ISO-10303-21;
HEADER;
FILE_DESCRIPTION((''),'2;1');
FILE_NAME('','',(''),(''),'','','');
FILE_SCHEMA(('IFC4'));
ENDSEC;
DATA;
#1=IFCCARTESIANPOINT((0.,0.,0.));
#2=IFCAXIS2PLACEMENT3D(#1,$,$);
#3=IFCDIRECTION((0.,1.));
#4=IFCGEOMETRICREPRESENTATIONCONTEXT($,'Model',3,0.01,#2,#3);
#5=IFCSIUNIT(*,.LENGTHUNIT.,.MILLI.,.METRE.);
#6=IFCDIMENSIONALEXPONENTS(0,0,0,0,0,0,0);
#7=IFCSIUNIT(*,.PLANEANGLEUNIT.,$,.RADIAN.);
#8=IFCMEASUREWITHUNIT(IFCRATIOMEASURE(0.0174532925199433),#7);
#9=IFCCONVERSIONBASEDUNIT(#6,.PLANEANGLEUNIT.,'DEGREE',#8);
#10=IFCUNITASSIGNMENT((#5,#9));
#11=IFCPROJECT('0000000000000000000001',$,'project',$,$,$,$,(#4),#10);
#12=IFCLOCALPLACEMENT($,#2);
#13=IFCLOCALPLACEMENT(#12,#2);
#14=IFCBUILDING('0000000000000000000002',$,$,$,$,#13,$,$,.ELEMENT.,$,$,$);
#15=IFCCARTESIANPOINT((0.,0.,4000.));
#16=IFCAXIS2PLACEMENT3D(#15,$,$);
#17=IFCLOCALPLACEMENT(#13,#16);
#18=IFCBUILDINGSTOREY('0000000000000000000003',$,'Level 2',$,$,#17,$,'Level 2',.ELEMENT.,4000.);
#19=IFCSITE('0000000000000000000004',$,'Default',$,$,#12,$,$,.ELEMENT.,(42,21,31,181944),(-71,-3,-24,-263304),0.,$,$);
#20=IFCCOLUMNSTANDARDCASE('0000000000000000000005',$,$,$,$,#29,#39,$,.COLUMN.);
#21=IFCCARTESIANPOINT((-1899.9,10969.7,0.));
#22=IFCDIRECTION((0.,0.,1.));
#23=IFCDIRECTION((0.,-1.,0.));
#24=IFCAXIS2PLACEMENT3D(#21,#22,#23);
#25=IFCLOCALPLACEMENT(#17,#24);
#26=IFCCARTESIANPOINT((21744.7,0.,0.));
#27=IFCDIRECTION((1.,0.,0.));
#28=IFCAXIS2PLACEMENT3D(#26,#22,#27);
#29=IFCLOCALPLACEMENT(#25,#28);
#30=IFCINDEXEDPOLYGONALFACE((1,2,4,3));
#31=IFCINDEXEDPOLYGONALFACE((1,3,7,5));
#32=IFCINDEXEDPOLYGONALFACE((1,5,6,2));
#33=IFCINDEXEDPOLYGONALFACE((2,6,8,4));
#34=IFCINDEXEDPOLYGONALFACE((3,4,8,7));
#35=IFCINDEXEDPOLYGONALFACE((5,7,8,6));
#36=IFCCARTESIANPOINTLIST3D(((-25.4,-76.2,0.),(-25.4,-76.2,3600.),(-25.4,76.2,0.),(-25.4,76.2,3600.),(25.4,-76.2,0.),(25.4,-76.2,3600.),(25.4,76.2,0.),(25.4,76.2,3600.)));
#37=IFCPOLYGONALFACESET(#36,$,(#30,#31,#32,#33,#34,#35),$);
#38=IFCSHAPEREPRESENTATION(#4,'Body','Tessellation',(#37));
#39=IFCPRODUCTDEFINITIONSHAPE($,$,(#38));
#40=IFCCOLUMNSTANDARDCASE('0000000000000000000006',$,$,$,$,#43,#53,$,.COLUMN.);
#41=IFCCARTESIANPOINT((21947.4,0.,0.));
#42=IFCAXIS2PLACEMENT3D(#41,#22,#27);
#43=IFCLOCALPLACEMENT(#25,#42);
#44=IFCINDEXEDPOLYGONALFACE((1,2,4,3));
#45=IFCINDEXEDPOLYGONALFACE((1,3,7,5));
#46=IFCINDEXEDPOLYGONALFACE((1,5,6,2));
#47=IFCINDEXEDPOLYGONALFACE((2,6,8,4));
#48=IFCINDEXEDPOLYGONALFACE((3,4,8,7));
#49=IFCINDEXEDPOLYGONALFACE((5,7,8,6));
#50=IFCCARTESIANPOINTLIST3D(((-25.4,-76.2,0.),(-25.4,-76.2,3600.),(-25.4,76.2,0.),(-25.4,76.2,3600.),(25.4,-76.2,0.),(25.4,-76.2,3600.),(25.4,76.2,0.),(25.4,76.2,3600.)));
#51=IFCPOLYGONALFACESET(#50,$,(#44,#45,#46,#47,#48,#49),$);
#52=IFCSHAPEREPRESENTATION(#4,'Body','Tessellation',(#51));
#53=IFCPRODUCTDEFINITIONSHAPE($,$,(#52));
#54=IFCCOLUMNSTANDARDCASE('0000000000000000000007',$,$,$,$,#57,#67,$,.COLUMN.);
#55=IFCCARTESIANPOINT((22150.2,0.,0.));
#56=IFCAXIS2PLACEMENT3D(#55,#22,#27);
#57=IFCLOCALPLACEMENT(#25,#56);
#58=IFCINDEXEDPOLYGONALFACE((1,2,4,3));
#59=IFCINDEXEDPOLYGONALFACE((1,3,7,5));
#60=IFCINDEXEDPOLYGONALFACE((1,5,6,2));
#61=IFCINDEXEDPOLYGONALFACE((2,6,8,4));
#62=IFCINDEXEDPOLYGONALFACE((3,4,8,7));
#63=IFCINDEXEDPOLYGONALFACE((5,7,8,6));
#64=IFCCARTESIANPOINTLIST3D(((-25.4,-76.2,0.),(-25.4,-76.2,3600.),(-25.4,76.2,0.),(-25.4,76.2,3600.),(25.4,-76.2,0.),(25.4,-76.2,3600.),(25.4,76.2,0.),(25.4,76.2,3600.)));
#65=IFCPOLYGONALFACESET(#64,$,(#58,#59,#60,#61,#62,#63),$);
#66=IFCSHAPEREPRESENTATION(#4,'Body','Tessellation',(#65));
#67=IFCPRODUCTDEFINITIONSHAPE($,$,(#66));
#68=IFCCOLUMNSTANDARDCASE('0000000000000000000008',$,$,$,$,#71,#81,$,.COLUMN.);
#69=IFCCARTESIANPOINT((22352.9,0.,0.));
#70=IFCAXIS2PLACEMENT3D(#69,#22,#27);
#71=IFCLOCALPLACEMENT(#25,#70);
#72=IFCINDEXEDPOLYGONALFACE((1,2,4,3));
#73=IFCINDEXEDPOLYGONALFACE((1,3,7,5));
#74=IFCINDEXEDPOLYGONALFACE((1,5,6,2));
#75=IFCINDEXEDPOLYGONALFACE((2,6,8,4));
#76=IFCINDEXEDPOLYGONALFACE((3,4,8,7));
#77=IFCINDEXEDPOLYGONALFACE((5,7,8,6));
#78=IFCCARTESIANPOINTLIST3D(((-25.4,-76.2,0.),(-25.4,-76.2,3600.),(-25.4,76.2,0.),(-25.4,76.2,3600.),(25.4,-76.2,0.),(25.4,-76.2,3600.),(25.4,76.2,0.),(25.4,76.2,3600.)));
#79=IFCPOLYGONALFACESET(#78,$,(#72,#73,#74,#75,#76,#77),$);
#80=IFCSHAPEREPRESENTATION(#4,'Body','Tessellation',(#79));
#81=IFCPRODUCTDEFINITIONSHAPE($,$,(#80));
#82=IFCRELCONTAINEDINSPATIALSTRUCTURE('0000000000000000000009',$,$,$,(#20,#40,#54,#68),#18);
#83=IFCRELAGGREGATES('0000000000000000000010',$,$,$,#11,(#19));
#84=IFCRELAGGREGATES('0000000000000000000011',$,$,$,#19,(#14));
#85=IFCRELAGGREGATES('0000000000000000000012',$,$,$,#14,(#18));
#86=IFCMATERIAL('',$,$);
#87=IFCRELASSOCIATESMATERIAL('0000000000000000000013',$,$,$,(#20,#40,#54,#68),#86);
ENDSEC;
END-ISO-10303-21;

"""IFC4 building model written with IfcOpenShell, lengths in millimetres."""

from ifc_helpers import new_model, entity, si_unit, converted_unit, direction, frame, origin, place, context, project, spatial, rectangle, extrude, material, element, save


model = new_model("IFC4")

# Units and contexts
model_context = context("Model", 3, precision=0.01, world=origin(), true_north=direction((0.0, 1.0)))
ifc_project = project(units=[si_unit("LENGTHUNIT", "METRE", prefix="MILLI"), converted_unit("PLANEANGLEUNIT", "DEGREE", entity("IfcRatioMeasure", 0.0174532925199433), si_unit("PLANEANGLEUNIT", "RADIAN"), dimensions=[0, 0, 0, 0, 0, 0, 0])], contexts=[model_context])

# Site, building, storey
site_placement = place(None, origin())
site = spatial("IfcSite", under=ifc_project, at=site_placement, Name="Default", CompositionType="ELEMENT", RefLatitude=(42, 21, 31, 181944), RefLongitude=(-71, -3, -24, -263304), RefElevation=0.0)
building_placement = place(site_placement, origin())
building = spatial("IfcBuilding", under=site, at=building_placement, CompositionType="ELEMENT")
storey_placement = place(building_placement, frame((0.0, 0.0, 4000.0)))
storey = spatial("IfcBuildingStorey", under=building, at=storey_placement, Name="Level 2", LongName="Level 2", CompositionType="ELEMENT", Elevation=4000.0)

# Columns
ifc_material = material(Name="")
placement = place(storey_placement, frame((-1899.9, 10969.7, 0.0), z_axis=(0.0, 0.0, 1.0), x_axis=(0.0, -1.0, 0.0)))
for number, where, z_axis, x_axis in (
    (1, (21744.7, 0.0, 0.0), (0.0, 0.0, 1.0), (1.0, 0.0, 0.0)),
    (2, (21947.4, 0.0, 0.0), (0.0, 0.0, 1.0), (1.0, 0.0, 0.0)),
    (3, (22150.2, 0.0, 0.0), (0.0, 0.0, 1.0), (1.0, 0.0, 0.0)),
    (4, (22352.9, 0.0, 0.0), (0.0, 0.0, 1.0), (1.0, 0.0, 0.0)),
):
    element("IfcColumnStandardCase", number, at=place(placement, frame(where, z_axis=z_axis, x_axis=x_axis)), inside=storey, material=ifc_material, PredefinedType="COLUMN", context=model_context, shape_type="SweptSolid", body=[
        extrude(rectangle(XDim=50.8, YDim=152.4), origin(), (0.0, 0.0, 1.0), 3600.0),
    ])

save(model, "model.ifc")
